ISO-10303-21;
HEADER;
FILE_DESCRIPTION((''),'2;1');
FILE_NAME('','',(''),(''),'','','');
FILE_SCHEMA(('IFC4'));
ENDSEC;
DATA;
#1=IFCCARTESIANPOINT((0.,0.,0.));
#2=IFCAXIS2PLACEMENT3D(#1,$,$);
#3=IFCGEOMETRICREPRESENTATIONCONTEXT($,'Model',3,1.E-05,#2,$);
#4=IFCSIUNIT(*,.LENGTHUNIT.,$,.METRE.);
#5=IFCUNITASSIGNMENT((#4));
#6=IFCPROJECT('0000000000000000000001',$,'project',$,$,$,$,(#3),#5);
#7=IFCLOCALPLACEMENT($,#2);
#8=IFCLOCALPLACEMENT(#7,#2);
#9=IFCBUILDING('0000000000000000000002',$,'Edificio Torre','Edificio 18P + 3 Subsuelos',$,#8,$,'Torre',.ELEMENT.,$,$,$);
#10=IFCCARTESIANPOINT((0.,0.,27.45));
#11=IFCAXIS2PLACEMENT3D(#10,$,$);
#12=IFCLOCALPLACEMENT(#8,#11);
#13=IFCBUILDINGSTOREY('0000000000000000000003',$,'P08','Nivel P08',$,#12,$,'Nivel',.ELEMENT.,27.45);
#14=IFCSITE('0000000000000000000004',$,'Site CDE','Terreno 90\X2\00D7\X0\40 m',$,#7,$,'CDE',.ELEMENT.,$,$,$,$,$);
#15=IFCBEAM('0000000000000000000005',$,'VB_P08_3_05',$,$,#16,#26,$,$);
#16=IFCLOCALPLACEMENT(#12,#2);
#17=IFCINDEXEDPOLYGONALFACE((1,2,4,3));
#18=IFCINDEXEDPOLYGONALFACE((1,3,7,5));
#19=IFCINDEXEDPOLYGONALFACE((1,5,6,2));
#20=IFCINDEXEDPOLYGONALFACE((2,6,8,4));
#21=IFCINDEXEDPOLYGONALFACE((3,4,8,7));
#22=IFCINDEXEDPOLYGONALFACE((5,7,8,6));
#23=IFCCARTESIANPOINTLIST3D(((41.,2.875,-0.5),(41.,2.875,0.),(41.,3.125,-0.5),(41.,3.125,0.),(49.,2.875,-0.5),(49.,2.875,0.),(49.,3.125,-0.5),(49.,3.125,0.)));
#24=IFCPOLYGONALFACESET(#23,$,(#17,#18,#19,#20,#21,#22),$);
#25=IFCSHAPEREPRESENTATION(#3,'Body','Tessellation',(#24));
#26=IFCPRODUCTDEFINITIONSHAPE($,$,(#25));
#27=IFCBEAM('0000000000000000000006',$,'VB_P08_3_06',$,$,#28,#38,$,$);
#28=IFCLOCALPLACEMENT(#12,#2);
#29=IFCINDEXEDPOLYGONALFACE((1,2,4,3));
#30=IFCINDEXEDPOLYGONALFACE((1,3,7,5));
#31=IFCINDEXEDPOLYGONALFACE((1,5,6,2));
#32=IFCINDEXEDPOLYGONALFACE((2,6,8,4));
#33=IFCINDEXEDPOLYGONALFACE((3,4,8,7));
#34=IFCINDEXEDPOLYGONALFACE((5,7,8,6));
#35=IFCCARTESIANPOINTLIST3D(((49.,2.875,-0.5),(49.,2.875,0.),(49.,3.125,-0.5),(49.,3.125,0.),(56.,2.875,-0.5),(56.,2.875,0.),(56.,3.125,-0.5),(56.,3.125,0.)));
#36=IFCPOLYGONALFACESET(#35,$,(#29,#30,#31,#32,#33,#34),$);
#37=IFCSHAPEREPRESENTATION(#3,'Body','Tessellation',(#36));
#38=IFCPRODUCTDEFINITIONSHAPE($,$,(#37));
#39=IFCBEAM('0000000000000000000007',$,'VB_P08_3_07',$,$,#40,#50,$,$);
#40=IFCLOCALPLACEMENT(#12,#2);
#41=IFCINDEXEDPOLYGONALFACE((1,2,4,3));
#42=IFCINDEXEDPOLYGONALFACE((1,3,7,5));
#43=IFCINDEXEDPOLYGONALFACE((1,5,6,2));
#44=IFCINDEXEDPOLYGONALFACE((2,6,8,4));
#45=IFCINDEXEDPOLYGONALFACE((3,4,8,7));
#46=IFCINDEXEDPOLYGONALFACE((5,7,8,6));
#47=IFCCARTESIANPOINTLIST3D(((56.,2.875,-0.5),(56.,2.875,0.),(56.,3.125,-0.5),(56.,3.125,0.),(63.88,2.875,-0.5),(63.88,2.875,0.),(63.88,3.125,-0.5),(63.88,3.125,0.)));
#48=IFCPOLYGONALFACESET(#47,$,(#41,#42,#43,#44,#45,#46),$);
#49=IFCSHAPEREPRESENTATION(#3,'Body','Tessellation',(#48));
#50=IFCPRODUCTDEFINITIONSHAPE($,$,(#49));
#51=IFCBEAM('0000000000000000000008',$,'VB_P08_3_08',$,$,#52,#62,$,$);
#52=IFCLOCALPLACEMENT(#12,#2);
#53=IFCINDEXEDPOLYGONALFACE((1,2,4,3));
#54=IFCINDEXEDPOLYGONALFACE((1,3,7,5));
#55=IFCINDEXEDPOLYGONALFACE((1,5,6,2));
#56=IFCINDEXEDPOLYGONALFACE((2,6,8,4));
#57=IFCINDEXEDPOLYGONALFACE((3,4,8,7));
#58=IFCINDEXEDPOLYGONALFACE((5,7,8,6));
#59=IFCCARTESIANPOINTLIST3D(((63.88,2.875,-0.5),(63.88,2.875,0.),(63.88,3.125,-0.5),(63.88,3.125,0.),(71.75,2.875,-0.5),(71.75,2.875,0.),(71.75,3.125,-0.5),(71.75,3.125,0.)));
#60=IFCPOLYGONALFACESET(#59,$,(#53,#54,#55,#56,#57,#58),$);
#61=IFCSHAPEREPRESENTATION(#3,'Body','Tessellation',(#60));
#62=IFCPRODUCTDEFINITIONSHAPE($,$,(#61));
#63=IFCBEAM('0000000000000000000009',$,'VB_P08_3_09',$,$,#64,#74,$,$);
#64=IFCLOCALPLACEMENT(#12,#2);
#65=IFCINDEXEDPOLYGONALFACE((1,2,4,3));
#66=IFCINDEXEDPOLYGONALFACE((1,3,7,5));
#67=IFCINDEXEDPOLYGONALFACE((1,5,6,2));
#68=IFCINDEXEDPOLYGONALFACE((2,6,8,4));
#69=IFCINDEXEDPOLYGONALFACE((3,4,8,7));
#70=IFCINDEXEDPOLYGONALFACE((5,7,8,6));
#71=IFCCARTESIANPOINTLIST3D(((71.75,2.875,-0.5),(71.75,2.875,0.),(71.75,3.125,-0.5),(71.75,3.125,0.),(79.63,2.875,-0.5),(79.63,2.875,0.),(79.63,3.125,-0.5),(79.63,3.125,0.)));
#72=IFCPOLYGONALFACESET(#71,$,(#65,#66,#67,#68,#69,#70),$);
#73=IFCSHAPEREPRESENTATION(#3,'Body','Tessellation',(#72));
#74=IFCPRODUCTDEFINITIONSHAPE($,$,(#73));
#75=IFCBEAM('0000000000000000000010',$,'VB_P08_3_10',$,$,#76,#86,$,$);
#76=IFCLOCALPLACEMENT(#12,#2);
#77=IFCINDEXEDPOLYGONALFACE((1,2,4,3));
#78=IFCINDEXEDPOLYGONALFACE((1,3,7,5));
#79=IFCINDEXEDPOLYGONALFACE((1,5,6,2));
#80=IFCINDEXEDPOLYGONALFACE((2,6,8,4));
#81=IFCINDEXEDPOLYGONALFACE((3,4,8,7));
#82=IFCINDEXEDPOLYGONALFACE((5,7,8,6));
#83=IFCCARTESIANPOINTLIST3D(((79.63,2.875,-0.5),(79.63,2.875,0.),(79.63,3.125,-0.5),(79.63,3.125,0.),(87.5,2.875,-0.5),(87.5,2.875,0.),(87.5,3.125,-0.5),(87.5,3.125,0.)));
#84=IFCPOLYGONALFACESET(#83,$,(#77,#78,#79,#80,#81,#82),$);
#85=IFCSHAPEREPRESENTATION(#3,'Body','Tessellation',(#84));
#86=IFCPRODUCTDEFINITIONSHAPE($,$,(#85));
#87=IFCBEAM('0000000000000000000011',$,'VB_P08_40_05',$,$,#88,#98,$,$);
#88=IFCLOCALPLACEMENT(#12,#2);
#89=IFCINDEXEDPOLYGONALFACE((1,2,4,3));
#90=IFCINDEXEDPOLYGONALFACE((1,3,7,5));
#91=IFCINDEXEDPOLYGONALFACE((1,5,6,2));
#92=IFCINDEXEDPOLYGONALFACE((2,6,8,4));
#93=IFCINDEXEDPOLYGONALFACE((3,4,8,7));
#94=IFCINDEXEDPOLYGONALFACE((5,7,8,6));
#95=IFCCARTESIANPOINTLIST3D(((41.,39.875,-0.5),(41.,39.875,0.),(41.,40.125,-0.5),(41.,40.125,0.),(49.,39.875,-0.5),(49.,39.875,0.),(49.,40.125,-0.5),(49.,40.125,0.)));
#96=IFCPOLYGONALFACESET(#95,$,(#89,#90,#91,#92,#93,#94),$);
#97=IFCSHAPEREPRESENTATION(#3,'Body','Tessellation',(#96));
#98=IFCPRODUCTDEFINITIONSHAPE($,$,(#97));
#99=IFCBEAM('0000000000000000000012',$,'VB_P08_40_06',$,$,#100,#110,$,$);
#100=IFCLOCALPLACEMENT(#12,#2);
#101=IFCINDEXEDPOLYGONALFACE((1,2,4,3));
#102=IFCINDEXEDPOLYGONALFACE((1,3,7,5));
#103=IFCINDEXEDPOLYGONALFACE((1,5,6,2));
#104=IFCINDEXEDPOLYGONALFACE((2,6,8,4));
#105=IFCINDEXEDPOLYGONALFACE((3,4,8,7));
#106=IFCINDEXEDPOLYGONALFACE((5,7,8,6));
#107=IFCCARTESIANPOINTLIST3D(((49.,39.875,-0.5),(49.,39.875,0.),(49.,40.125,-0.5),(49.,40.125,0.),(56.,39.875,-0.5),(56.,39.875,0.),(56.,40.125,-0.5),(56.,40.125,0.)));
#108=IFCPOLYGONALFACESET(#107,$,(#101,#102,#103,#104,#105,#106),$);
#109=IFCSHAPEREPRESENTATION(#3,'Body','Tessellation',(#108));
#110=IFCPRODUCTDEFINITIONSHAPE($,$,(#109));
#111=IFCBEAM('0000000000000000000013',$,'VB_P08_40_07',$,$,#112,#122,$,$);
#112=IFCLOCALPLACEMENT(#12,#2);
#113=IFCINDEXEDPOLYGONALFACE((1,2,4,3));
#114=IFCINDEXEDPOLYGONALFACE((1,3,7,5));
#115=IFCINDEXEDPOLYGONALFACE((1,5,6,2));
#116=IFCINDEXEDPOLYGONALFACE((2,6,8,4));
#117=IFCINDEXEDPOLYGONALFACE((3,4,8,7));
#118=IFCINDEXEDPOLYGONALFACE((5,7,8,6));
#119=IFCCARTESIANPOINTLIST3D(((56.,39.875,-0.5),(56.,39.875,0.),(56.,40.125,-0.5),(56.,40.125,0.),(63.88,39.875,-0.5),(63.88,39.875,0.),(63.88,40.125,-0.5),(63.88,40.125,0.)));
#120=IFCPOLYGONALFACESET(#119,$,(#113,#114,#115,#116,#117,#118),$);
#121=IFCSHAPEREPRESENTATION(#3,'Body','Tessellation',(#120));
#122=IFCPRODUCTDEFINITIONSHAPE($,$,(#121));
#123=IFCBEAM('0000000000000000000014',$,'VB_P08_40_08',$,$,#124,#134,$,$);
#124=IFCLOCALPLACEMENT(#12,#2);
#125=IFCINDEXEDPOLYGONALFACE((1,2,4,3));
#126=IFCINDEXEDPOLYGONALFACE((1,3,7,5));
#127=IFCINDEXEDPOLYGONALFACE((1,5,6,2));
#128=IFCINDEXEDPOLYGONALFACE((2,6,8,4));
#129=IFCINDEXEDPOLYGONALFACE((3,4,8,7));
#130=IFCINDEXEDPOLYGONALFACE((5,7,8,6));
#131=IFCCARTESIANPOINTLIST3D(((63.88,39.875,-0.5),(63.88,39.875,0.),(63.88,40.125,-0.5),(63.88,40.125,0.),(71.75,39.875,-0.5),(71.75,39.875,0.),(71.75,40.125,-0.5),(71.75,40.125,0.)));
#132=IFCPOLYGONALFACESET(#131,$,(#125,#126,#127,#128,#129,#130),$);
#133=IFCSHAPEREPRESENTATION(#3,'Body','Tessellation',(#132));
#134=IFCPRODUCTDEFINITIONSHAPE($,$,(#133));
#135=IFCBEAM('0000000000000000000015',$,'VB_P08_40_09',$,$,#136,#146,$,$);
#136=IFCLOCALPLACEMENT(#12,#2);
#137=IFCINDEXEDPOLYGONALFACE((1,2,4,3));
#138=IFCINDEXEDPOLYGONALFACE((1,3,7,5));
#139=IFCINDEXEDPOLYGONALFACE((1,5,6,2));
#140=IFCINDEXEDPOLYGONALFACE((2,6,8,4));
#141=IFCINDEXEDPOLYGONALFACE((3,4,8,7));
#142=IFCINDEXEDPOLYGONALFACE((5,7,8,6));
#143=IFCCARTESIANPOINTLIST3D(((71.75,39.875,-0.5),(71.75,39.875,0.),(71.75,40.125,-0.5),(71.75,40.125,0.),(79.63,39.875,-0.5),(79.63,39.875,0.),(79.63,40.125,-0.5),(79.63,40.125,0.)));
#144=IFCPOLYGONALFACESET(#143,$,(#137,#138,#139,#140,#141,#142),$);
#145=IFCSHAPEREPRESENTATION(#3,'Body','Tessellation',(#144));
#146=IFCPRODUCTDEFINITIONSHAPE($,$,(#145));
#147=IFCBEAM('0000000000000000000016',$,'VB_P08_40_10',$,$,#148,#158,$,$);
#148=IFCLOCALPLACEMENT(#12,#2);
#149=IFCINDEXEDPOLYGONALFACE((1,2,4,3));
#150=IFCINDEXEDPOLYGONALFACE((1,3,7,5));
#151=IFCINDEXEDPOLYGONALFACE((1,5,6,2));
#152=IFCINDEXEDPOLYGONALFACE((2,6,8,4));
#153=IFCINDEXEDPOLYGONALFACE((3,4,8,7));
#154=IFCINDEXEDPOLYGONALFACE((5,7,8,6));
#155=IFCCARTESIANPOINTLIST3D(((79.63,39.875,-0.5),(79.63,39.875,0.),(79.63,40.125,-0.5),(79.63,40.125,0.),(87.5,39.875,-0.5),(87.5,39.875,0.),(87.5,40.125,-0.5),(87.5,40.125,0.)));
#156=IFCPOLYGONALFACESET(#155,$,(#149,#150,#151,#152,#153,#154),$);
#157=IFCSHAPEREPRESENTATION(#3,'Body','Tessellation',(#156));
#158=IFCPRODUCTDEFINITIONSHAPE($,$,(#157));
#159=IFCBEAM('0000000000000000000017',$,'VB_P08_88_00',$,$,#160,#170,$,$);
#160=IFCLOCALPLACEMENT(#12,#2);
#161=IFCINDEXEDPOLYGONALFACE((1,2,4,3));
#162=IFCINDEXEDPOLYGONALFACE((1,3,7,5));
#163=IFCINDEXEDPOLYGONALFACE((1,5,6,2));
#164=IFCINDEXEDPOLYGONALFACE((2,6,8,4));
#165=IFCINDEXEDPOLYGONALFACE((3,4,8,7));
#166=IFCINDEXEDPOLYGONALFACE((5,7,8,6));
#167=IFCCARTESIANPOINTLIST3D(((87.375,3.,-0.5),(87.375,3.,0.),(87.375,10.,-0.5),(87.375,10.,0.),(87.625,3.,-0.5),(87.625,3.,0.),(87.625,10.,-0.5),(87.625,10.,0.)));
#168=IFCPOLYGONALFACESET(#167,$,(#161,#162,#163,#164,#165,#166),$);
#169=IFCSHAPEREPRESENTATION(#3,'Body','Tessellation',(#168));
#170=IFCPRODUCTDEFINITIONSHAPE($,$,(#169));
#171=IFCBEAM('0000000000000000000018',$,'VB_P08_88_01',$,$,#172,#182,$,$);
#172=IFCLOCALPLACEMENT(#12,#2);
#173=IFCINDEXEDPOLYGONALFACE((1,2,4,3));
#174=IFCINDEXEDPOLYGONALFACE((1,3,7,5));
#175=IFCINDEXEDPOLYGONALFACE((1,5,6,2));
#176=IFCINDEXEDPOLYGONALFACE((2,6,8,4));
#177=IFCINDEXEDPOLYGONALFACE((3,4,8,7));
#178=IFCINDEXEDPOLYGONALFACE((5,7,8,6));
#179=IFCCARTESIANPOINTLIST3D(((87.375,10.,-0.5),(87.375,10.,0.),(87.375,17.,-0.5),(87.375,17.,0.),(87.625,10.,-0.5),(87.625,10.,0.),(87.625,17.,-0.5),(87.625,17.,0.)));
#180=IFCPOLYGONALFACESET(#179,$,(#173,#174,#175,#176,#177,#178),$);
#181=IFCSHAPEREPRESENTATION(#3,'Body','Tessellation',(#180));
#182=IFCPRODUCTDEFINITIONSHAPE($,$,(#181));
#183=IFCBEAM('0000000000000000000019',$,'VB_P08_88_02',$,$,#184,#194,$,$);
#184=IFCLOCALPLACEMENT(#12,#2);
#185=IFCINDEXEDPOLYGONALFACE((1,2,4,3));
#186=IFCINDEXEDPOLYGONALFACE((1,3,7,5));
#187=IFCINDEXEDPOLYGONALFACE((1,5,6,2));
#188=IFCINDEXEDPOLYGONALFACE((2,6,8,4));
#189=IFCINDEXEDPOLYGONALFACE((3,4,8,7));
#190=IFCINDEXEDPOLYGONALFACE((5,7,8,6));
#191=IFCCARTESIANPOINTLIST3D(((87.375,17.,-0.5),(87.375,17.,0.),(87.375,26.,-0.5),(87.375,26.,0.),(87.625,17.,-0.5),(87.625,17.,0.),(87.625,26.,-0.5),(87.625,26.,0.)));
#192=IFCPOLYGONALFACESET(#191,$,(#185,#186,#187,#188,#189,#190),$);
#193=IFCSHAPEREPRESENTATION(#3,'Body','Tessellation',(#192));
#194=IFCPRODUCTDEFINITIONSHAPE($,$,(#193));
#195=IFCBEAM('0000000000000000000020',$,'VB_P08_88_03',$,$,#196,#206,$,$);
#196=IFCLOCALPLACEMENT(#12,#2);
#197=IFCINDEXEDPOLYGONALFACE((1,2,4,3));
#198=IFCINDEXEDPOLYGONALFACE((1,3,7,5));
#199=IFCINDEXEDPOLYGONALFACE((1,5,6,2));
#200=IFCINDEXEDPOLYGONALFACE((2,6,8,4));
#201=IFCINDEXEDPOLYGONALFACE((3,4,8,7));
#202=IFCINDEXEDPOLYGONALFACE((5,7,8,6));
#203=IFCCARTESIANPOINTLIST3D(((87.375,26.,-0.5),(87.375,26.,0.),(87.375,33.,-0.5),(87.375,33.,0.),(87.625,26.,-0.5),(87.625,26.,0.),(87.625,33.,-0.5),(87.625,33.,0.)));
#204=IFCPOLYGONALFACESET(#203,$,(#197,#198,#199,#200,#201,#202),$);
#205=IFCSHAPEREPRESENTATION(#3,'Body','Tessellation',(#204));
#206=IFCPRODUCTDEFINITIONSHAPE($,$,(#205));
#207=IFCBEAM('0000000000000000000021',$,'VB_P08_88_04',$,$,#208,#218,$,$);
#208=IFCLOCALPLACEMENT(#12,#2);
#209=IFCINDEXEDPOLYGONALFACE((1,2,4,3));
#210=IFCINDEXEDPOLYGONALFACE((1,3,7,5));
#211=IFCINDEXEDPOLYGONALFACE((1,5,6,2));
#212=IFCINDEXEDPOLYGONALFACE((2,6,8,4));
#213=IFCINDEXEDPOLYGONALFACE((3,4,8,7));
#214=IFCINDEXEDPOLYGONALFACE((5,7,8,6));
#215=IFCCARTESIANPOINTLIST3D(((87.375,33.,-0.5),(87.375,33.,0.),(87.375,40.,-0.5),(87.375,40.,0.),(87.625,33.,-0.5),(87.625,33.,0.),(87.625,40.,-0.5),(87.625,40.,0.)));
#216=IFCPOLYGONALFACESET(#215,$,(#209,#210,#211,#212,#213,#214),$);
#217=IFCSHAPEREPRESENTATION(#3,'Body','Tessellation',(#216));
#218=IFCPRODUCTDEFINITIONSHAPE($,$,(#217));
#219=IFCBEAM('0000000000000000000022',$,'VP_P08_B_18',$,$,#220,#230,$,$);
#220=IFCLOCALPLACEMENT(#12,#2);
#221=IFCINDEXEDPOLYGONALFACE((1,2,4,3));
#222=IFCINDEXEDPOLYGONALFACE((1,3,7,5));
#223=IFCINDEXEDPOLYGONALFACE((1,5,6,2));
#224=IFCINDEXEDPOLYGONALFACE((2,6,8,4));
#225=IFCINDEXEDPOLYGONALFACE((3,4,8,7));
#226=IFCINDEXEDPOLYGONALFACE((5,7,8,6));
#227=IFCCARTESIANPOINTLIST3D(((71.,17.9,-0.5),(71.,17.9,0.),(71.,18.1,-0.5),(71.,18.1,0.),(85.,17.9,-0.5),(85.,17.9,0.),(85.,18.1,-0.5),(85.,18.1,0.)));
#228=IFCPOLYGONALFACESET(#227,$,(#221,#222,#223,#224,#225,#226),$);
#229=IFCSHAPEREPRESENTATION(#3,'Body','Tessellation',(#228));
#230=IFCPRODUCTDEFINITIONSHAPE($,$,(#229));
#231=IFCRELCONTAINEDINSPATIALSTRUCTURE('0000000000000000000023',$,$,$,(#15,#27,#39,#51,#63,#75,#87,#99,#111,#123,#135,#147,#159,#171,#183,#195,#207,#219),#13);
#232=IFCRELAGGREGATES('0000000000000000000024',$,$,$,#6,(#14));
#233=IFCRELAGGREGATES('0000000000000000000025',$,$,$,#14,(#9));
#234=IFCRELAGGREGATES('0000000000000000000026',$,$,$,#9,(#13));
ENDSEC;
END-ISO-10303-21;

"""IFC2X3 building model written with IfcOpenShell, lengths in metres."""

from ifc_helpers import new_model, si_unit, frame, origin, origin_2d, place, context, project, spatial, rectangle, extrude, element, save


model = new_model("IFC2X3")

# Units and contexts
model_context = context("Model", 3, precision=1e-05, world=origin())
ifc_project = project(units=[si_unit("LENGTHUNIT", "METRE")], contexts=[model_context])

# Site, building, storey
site_placement = place(None, origin())
site = spatial("IfcSite", under=ifc_project, at=site_placement, Name="Site CDE", Description="Terreno 90×40 m", LongName="CDE", CompositionType="ELEMENT")
building_placement = place(site_placement, origin())
building = spatial("IfcBuilding", under=site, at=building_placement, Name="Edificio Torre", Description="Edificio 18P + 3 Subsuelos", LongName="Torre", CompositionType="ELEMENT")
storey_placement = place(building_placement, frame((0.0, 0.0, 27.45)))
storey = spatial("IfcBuildingStorey", under=building, at=storey_placement, Name="P08", Description="Nivel P08", LongName="Nivel", CompositionType="ELEMENT", Elevation=27.45)

# Beams
beam_1_placement = place(storey_placement, frame((45.0, 3.0, -0.5)))
element("IfcBeam", 1, at=beam_1_placement, inside=storey, Name="VB_P08_3_05", context=model_context, shape_type="SweptSolid", body=[
    extrude(rectangle(XDim=8.0, YDim=0.25, at=origin_2d()), origin(), (0.0, 0.0, 1.0), 0.5),
])
beam_2_placement = place(storey_placement, frame((52.5, 3.0, -0.5)))
element("IfcBeam", 2, at=beam_2_placement, inside=storey, Name="VB_P08_3_06", context=model_context, shape_type="SweptSolid", body=[
    extrude(rectangle(XDim=7.0, YDim=0.25, at=origin_2d()), origin(), (0.0, 0.0, 1.0), 0.5),
])
beam_3_placement = place(storey_placement, frame((59.94, 3.0, -0.5)))
element("IfcBeam", 3, at=beam_3_placement, inside=storey, Name="VB_P08_3_07", context=model_context, shape_type="SweptSolid", body=[
    extrude(rectangle(XDim=7.88, YDim=0.25, at=origin_2d()), origin(), (0.0, 0.0, 1.0), 0.5),
])
beam_4_placement = place(storey_placement, frame((67.815, 3.0, -0.5)))
element("IfcBeam", 4, at=beam_4_placement, inside=storey, Name="VB_P08_3_08", context=model_context, shape_type="SweptSolid", body=[
    extrude(rectangle(XDim=7.87, YDim=0.25, at=origin_2d()), origin(), (0.0, 0.0, 1.0), 0.5),
])
beam_5_placement = place(storey_placement, frame((75.69, 3.0, -0.5)))
element("IfcBeam", 5, at=beam_5_placement, inside=storey, Name="VB_P08_3_09", context=model_context, shape_type="SweptSolid", body=[
    extrude(rectangle(XDim=7.88, YDim=0.25, at=origin_2d()), origin(), (0.0, 0.0, 1.0), 0.5),
])
beam_6_placement = place(storey_placement, frame((83.565, 3.0, -0.5)))
element("IfcBeam", 6, at=beam_6_placement, inside=storey, Name="VB_P08_3_10", context=model_context, shape_type="SweptSolid", body=[
    extrude(rectangle(XDim=7.87, YDim=0.25, at=origin_2d()), origin(), (0.0, 0.0, 1.0), 0.5),
])
beam_7_placement = place(storey_placement, frame((45.0, 40.0, -0.5)))
element("IfcBeam", 7, at=beam_7_placement, inside=storey, Name="VB_P08_40_05", context=model_context, shape_type="SweptSolid", body=[
    extrude(rectangle(XDim=8.0, YDim=0.25, at=origin_2d()), origin(), (0.0, 0.0, 1.0), 0.5),
])
beam_8_placement = place(storey_placement, frame((52.5, 40.0, -0.5)))
element("IfcBeam", 8, at=beam_8_placement, inside=storey, Name="VB_P08_40_06", context=model_context, shape_type="SweptSolid", body=[
    extrude(rectangle(XDim=7.0, YDim=0.25, at=origin_2d()), origin(), (0.0, 0.0, 1.0), 0.5),
])
beam_9_placement = place(storey_placement, frame((59.94, 40.0, -0.5)))
element("IfcBeam", 9, at=beam_9_placement, inside=storey, Name="VB_P08_40_07", context=model_context, shape_type="SweptSolid", body=[
    extrude(rectangle(XDim=7.88, YDim=0.25, at=origin_2d()), origin(), (0.0, 0.0, 1.0), 0.5),
])
beam_10_placement = place(storey_placement, frame((67.815, 40.0, -0.5)))
element("IfcBeam", 10, at=beam_10_placement, inside=storey, Name="VB_P08_40_08", context=model_context, shape_type="SweptSolid", body=[
    extrude(rectangle(XDim=7.87, YDim=0.25, at=origin_2d()), origin(), (0.0, 0.0, 1.0), 0.5),
])
beam_11_placement = place(storey_placement, frame((75.69, 40.0, -0.5)))
element("IfcBeam", 11, at=beam_11_placement, inside=storey, Name="VB_P08_40_09", context=model_context, shape_type="SweptSolid", body=[
    extrude(rectangle(XDim=7.88, YDim=0.25, at=origin_2d()), origin(), (0.0, 0.0, 1.0), 0.5),
])
beam_12_placement = place(storey_placement, frame((83.565, 40.0, -0.5)))
element("IfcBeam", 12, at=beam_12_placement, inside=storey, Name="VB_P08_40_10", context=model_context, shape_type="SweptSolid", body=[
    extrude(rectangle(XDim=7.87, YDim=0.25, at=origin_2d()), origin(), (0.0, 0.0, 1.0), 0.5),
])
for number, where, name in (
    (13, (87.5, 6.5, -0.5), "VB_P08_88_00"),
    (14, (87.5, 13.5, -0.5), "VB_P08_88_01"),
):
    element("IfcBeam", number, at=place(storey_placement, frame(where)), inside=storey, Name=name, context=model_context, shape_type="SweptSolid", body=[
        extrude(rectangle(XDim=0.25, YDim=7.0, at=origin_2d()), origin(), (0.0, 0.0, 1.0), 0.5),
    ])
beam_13_placement = place(storey_placement, frame((87.5, 21.5, -0.5)))
element("IfcBeam", 15, at=beam_13_placement, inside=storey, Name="VB_P08_88_02", context=model_context, shape_type="SweptSolid", body=[
    extrude(rectangle(XDim=0.25, YDim=9.0, at=origin_2d()), origin(), (0.0, 0.0, 1.0), 0.5),
])
for number, where, name in (
    (16, (87.5, 29.5, -0.5), "VB_P08_88_03"),
    (17, (87.5, 36.5, -0.5), "VB_P08_88_04"),
):
    element("IfcBeam", number, at=place(storey_placement, frame(where)), inside=storey, Name=name, context=model_context, shape_type="SweptSolid", body=[
        extrude(rectangle(XDim=0.25, YDim=7.0, at=origin_2d()), origin(), (0.0, 0.0, 1.0), 0.5),
    ])
for number, where, name in (
    (18, (78.0, 18.0, -0.5), "VP_P08_B_18"),
):
    element("IfcBeam", number, at=place(storey_placement, frame(where)), inside=storey, Name=name, context=model_context, shape_type="SweptSolid", body=[
        extrude(rectangle(XDim=14.0, YDim=0.2, at=origin_2d()), origin(), (0.0, 0.0, 1.0), 0.5),
    ])

save(model, "model.ifc")
